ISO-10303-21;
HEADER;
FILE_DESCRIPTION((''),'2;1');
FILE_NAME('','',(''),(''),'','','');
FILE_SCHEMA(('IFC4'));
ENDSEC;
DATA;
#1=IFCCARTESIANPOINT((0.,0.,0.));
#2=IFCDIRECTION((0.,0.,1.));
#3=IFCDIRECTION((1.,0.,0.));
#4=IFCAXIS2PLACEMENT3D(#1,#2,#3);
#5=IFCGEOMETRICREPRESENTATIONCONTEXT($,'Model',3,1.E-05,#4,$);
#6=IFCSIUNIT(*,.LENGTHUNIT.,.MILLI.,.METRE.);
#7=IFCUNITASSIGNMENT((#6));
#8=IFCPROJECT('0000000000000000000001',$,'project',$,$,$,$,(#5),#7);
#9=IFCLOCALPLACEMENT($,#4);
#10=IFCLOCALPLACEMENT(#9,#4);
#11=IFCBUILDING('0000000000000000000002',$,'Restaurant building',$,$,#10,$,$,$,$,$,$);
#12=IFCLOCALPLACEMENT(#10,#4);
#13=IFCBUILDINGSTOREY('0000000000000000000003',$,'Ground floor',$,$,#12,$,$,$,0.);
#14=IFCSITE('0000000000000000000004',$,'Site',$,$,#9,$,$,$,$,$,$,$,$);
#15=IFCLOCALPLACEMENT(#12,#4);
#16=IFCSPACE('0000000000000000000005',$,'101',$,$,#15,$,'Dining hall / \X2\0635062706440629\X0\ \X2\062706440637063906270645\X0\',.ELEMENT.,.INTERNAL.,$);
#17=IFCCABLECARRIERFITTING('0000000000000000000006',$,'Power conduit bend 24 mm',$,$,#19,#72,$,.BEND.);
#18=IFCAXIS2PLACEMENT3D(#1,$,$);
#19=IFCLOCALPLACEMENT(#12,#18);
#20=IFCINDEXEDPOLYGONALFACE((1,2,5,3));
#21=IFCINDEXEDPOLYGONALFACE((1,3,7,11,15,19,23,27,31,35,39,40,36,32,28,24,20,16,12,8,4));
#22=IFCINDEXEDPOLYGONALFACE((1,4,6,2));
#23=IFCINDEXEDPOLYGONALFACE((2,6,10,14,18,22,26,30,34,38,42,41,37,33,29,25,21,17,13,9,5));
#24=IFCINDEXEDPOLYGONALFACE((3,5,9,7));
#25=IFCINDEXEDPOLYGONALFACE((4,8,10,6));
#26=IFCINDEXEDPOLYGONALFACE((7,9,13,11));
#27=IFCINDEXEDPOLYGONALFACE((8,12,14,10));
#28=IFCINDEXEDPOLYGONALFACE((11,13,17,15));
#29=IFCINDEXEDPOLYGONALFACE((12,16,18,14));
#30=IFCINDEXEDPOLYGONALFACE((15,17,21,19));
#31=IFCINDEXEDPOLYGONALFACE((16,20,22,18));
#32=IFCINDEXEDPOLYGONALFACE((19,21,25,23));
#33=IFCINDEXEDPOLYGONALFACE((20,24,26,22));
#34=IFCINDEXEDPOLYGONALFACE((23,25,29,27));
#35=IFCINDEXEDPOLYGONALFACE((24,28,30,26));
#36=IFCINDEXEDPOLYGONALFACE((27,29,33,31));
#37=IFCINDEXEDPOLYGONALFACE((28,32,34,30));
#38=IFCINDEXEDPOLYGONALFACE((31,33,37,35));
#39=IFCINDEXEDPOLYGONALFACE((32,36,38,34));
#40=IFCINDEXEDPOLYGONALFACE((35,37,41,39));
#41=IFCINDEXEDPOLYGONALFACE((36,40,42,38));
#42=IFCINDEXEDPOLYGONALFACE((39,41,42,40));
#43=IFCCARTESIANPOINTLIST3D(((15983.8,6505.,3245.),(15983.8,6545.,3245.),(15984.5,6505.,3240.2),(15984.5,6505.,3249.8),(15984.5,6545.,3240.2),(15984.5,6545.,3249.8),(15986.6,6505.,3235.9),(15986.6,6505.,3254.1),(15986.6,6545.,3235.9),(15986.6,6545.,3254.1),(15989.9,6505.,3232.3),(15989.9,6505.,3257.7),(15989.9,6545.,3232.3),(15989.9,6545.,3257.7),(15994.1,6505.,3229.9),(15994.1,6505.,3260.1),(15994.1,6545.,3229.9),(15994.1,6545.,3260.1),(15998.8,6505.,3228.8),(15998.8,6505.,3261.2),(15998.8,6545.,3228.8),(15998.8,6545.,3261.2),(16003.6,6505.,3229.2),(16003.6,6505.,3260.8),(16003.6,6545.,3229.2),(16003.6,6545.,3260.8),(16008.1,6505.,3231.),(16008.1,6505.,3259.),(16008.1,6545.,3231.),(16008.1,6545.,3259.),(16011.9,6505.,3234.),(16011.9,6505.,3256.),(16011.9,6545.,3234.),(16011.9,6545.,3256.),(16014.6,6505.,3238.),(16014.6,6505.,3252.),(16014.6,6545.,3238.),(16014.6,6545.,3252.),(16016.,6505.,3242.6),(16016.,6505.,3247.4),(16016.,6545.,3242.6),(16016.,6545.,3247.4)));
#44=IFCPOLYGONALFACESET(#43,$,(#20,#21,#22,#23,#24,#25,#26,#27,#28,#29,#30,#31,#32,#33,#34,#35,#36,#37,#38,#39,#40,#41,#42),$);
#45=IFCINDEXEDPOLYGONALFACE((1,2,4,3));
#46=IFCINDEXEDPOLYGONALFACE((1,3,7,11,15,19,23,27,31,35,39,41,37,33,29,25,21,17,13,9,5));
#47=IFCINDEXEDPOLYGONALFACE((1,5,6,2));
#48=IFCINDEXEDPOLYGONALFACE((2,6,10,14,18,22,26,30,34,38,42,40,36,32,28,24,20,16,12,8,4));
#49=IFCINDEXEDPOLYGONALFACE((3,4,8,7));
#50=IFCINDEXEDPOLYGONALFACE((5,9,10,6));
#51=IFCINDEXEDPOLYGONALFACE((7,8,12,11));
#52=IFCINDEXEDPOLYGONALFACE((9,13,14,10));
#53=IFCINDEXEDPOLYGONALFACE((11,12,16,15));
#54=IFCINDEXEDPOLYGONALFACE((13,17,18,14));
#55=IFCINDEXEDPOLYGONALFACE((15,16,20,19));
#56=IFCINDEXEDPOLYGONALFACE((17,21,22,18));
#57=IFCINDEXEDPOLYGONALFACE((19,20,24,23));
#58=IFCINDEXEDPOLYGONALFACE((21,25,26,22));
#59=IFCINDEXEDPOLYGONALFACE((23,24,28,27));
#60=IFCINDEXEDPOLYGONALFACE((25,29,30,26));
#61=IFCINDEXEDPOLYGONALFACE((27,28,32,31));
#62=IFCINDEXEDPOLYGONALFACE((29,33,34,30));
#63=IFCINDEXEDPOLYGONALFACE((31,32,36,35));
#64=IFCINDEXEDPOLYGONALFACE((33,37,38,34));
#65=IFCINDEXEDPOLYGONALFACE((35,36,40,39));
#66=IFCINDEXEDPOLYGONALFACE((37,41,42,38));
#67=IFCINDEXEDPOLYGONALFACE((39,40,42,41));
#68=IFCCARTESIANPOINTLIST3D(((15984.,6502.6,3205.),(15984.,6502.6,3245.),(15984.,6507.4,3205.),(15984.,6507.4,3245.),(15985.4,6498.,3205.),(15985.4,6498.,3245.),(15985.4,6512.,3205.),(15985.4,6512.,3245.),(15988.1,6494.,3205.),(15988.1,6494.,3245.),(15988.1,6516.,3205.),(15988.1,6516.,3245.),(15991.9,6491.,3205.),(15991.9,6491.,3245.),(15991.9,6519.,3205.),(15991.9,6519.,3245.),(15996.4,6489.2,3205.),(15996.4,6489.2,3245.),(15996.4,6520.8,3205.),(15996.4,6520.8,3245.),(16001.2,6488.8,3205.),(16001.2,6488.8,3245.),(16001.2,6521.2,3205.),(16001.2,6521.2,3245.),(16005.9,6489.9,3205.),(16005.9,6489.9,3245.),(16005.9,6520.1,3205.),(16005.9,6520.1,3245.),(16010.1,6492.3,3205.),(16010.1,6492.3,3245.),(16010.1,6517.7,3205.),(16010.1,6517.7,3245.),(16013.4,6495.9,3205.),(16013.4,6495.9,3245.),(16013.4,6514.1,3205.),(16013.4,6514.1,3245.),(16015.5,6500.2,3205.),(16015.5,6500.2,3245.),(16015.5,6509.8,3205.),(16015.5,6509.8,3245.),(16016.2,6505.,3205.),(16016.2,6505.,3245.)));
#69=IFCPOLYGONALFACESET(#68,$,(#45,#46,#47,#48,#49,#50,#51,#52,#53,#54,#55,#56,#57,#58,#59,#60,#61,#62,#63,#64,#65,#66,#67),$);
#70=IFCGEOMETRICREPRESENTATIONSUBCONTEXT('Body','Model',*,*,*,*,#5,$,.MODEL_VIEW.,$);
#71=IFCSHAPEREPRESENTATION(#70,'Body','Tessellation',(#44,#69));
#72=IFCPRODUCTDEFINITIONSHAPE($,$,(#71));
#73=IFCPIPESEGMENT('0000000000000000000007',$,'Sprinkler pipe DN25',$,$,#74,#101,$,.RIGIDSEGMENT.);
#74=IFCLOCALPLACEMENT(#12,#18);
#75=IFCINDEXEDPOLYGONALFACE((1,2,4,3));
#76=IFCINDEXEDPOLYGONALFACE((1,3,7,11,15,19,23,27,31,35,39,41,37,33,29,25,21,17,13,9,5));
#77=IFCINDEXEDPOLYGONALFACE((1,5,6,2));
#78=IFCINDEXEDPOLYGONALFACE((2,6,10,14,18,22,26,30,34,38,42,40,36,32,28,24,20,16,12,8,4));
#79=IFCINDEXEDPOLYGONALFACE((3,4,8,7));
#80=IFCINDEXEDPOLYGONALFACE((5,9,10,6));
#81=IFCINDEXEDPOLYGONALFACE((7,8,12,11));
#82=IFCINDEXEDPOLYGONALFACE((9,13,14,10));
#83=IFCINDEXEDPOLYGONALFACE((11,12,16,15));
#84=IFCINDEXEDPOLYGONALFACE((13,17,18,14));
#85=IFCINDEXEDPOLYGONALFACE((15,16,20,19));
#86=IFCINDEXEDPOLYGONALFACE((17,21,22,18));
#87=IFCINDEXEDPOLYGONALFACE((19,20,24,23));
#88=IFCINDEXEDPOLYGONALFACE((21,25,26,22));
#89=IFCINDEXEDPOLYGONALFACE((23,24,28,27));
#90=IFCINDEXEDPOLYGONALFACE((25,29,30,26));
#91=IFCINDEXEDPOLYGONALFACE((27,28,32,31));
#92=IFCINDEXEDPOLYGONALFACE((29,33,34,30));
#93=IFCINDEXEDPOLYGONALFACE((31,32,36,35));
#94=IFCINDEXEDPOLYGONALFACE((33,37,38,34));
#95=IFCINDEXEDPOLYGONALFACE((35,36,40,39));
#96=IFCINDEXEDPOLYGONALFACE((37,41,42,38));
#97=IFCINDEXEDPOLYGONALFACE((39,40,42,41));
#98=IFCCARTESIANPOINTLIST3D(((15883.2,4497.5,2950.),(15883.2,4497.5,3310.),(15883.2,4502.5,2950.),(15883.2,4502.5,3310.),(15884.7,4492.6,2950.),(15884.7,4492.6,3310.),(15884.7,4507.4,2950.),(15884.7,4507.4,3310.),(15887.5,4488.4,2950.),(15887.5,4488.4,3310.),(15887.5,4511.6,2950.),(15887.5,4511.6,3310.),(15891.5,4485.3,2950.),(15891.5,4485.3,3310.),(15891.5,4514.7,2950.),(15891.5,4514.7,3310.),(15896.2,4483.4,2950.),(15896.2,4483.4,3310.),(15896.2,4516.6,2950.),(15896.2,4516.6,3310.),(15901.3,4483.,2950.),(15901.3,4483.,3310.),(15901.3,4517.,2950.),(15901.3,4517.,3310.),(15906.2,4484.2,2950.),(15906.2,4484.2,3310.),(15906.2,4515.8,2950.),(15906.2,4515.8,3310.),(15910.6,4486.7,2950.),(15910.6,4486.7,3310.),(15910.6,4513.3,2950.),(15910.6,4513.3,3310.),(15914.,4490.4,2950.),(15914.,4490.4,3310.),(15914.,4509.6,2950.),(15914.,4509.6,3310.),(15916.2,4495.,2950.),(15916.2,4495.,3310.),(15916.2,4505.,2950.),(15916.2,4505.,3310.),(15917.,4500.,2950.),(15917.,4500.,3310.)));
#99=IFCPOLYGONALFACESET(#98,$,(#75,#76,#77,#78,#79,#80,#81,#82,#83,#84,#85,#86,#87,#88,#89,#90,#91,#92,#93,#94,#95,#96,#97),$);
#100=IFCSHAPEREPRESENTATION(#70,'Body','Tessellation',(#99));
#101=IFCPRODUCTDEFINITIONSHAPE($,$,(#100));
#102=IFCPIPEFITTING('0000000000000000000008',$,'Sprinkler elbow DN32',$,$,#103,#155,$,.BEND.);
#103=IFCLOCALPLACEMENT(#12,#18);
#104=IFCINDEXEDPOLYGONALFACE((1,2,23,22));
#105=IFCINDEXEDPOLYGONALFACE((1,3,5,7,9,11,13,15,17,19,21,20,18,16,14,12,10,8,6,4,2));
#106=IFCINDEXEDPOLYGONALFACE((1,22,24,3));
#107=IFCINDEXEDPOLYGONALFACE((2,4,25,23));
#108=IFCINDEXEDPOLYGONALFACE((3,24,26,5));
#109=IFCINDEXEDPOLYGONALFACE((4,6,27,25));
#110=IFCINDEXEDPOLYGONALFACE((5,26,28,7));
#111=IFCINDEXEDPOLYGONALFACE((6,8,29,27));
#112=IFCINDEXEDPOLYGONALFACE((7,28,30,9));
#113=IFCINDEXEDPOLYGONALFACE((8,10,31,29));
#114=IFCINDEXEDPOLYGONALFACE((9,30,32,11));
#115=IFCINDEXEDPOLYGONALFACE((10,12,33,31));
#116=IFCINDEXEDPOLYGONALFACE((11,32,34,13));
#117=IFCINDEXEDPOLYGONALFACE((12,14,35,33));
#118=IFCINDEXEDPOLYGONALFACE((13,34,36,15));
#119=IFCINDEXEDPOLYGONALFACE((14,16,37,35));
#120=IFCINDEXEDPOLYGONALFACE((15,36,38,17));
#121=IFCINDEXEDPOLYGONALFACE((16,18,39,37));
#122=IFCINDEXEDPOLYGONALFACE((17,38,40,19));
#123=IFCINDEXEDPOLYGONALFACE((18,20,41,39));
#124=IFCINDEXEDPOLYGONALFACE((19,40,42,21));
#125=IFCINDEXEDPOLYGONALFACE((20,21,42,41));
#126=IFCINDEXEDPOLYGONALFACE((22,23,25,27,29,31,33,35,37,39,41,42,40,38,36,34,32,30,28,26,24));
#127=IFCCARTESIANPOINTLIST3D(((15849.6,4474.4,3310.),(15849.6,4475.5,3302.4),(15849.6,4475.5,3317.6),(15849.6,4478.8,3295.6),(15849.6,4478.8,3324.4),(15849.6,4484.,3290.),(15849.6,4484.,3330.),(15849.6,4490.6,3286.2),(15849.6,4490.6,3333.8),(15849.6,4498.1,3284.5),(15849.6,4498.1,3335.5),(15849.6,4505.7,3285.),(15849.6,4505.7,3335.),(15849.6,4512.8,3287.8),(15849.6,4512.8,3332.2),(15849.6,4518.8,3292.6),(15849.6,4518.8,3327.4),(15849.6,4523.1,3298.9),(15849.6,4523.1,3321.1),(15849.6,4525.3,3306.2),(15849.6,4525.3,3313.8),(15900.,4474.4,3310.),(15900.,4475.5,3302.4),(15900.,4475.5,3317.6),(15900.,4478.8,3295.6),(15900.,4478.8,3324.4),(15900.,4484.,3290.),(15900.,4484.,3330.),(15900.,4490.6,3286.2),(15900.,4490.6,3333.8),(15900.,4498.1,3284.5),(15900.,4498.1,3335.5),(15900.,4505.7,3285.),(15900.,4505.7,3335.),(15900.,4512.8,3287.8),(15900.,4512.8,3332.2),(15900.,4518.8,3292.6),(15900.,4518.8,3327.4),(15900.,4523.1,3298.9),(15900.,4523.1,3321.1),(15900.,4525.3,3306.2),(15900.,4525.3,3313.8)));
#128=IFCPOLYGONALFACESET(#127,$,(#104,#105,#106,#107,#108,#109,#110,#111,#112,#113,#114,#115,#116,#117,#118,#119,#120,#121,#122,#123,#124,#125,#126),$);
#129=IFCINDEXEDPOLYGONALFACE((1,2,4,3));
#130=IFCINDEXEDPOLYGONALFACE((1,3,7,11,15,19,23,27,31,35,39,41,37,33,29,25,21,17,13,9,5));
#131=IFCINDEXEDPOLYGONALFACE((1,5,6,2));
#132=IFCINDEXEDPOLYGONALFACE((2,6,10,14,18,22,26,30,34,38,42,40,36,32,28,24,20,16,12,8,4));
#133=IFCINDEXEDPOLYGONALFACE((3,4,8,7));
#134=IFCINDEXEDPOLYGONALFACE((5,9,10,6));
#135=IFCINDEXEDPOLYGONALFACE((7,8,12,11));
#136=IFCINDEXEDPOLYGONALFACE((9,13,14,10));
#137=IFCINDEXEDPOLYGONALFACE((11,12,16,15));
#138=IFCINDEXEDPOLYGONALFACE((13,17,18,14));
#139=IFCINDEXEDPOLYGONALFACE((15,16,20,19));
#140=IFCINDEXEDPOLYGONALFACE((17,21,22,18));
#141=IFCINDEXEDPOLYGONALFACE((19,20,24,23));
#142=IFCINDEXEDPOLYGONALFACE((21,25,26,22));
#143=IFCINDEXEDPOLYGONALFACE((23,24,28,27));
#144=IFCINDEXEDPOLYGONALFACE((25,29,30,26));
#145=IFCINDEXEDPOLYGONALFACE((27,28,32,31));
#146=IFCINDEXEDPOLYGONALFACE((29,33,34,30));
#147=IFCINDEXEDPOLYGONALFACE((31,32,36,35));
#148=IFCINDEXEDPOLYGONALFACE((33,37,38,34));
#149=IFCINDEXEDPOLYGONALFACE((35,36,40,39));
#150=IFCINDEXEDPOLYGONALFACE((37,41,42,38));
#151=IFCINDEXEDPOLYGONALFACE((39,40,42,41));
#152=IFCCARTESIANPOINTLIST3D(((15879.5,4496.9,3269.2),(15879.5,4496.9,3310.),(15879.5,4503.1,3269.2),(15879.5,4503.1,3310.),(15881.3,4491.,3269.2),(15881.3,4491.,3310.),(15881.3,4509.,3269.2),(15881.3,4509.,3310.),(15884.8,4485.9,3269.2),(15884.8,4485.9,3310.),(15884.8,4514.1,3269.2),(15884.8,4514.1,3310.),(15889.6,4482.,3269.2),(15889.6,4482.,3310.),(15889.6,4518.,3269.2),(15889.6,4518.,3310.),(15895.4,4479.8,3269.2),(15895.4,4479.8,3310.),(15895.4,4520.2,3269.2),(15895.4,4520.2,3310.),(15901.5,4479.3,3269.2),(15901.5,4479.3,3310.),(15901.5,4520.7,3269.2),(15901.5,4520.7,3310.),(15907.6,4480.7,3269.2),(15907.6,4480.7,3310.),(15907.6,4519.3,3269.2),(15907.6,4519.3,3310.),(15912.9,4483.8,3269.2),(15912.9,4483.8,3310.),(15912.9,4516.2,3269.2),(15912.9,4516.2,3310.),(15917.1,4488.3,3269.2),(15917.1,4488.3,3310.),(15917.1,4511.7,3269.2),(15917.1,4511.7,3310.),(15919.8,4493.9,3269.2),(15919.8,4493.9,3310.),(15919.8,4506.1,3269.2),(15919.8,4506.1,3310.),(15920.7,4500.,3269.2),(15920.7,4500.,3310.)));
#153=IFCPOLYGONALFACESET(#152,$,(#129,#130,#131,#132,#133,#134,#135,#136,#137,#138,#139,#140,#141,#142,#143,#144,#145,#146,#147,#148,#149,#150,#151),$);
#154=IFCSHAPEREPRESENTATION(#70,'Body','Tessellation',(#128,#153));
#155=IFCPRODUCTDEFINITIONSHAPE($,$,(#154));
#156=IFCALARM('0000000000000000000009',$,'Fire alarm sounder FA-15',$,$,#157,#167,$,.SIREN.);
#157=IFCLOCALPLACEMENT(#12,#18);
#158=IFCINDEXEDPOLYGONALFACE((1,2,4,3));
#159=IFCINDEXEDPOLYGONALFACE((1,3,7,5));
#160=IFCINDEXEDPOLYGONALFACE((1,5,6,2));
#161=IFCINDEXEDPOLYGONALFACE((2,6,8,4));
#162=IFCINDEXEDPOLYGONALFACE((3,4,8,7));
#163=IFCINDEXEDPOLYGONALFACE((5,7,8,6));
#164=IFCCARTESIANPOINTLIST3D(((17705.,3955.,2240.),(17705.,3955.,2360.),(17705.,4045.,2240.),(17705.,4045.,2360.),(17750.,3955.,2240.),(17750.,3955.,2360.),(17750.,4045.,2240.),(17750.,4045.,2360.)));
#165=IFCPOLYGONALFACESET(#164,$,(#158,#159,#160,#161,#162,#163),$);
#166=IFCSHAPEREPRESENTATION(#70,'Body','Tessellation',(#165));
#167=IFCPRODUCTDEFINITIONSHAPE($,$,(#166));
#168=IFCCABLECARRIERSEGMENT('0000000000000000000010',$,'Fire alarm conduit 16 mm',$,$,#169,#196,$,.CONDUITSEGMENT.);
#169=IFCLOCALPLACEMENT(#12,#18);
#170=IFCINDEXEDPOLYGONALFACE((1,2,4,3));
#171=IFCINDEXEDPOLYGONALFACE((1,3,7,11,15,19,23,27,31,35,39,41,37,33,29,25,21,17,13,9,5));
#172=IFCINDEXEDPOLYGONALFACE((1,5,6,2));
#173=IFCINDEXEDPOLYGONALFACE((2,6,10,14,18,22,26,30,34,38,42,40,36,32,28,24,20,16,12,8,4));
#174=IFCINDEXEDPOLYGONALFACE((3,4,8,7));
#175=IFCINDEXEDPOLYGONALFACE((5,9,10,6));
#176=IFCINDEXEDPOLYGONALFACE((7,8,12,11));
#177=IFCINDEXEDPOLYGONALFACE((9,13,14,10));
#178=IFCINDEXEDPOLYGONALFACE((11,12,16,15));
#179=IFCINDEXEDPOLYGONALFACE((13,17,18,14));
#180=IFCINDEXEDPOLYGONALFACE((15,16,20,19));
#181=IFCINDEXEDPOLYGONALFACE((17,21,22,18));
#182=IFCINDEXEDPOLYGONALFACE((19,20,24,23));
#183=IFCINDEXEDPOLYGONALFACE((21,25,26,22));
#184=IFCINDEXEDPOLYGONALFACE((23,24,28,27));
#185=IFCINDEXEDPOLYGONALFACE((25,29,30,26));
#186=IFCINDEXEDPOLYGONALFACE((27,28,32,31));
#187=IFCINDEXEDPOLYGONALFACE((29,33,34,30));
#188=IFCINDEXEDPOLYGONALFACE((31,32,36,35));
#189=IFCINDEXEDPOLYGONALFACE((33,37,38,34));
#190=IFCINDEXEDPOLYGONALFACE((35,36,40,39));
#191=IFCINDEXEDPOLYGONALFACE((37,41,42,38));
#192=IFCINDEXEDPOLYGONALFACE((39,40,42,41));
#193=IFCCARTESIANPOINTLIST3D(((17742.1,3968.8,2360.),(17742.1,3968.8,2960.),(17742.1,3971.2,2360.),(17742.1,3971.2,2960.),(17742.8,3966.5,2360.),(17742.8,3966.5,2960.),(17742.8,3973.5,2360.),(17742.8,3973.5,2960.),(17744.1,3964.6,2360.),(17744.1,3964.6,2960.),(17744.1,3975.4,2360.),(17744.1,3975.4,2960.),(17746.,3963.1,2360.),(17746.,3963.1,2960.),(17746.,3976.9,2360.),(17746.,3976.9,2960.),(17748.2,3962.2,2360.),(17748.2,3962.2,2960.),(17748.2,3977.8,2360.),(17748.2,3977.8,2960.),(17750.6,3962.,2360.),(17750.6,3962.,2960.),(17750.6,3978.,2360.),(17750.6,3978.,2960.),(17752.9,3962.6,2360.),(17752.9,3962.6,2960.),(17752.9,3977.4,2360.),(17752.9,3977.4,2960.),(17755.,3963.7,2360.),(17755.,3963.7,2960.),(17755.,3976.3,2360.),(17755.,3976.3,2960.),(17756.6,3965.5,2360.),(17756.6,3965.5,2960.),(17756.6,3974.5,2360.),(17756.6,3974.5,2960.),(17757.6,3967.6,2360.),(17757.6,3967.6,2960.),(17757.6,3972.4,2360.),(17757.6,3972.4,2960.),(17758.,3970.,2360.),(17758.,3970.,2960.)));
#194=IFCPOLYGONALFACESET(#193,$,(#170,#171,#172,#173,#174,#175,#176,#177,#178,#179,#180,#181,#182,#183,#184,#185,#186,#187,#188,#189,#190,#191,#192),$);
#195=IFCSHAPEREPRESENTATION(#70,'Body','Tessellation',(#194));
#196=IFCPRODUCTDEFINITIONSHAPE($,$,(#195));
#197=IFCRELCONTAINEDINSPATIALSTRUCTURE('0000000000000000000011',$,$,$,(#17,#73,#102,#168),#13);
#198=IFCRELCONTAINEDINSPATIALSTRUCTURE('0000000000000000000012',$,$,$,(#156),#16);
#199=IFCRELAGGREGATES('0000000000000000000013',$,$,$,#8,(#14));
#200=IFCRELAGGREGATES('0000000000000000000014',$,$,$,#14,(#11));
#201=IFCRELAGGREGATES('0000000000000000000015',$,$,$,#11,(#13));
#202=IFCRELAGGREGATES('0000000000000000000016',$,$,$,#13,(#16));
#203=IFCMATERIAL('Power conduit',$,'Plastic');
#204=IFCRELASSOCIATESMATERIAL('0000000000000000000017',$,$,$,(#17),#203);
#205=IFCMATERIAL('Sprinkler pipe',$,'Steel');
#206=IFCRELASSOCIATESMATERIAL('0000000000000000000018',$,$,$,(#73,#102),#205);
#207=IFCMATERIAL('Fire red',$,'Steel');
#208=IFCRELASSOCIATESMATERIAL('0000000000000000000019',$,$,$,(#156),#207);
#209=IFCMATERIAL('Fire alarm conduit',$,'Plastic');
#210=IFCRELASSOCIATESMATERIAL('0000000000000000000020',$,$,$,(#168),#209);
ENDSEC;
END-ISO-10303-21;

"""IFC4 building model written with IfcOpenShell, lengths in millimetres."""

from ifc_helpers import new_model, si_unit, frame, origin_with_axes, origin_2d, place, context, subcontext, project, spatial, rectangle, circle, extrude, material, element, save


model = new_model("IFC4")

# Units and contexts
model_context = context("Model", 3, precision=1e-05, world=origin_with_axes())
body_context = subcontext(model_context, "Body", "Model", "MODEL_VIEW")
ifc_project = project(units=[si_unit("LENGTHUNIT", "METRE", prefix="MILLI")], contexts=[model_context])

# Site, building, storey
site_placement = place(None, origin_with_axes())
site = spatial("IfcSite", under=ifc_project, at=site_placement, Name="Site")
building_placement = place(site_placement, origin_with_axes())
building = spatial("IfcBuilding", under=site, at=building_placement, Name="Restaurant building")
storey_placement = place(building_placement, origin_with_axes())
storey = spatial("IfcBuildingStorey", under=building, at=storey_placement, Name="Ground floor", Elevation=0.0)

# Shared definitions
space_1_placement = place(storey_placement, origin_with_axes())
space_1 = spatial("IfcSpace", under=storey, at=space_1_placement, Name="101", LongName="Dining hall / صالة الطعام", CompositionType="ELEMENT", PredefinedType="INTERNAL")

# Shared definitions
ifc_material_1 = material(Name="Power conduit", Category="Plastic")

# Cable carrier fitting
for number, where, name in (
    (1, (16000.0, 6505.0, 3245.0), "Power conduit bend 24 mm"),
):
    element("IfcCableCarrierFitting", number, at=place(storey_placement, frame(where)), inside=storey, material=ifc_material_1, Name=name, PredefinedType="BEND", context=body_context, shape_type="SweptSolid", body=[
        extrude(circle(Radius=16.2, at=origin_2d()), frame((0.0, 0.0, 0.0), z_axis=(0.0, 1.0, 0.0), x_axis=(-1.0, 0.0, 0.0)), (0.0, 0.0, 1.0), 40.0),
        extrude(circle(Radius=16.2, at=origin_2d()), frame((0.0, 0.0, 0.0), z_axis=(0.0, 0.0, -1.0), x_axis=(1.0, 0.0, 0.0)), (0.0, 0.0, 1.0), 40.0),
    ])

# Pipe segment
ifc_material_2 = material(Name="Sprinkler pipe", Category="Steel")
pipe_segment_placement = place(storey_placement, frame((15900.0, 4500.0, 3310.0)))
element("IfcPipeSegment", 2, at=pipe_segment_placement, inside=storey, material=ifc_material_2, Name="Sprinkler pipe DN25", PredefinedType="RIGIDSEGMENT", context=body_context, shape_type="SweptSolid", body=[
    extrude(circle(Radius=17.0, at=origin_2d()), frame((0.0, 0.0, 0.0), z_axis=(0.0, 0.0, -1.0), x_axis=(1.0, 0.0, 0.0)), (0.0, 0.0, 1.0), 360.0),
])

# Pipe fitting
pipe_fitting_placement = place(storey_placement, frame((15900.0, 4500.0, 3310.0)))
element("IfcPipeFitting", 3, at=pipe_fitting_placement, inside=storey, material=ifc_material_2, Name="Sprinkler elbow DN32", PredefinedType="BEND", context=body_context, shape_type="SweptSolid", body=[
    extrude(circle(Radius=25.6, at=origin_2d()), frame((0.0, 0.0, 0.0), z_axis=(-1.0, 0.0, 0.0), x_axis=(0.0, -1.0, 0.0)), (0.0, 0.0, 1.0), 50.4),
    extrude(circle(Radius=20.7, at=origin_2d()), frame((0.0, 0.0, 0.0), z_axis=(0.0, 0.0, -1.0), x_axis=(1.0, 0.0, 0.0)), (0.0, 0.0, 1.0), 40.8),
])

# Alarm
ifc_material_3 = material(Name="Fire red", Category="Steel")
alarm_placement = place(storey_placement, frame((17750.0, 4000.0, 2300.0)))
element("IfcAlarm", 4, at=alarm_placement, inside=space_1, material=ifc_material_3, Name="Fire alarm sounder FA-15", PredefinedType="SIREN", context=body_context, shape_type="SweptSolid", body=[
    extrude(rectangle(XDim=45.0, YDim=90.0, at=origin_2d()), frame((-22.5, 0.0, -60.0)), (0.0, 0.0, 1.0), 120.0),
])

# Cable carrier segment
ifc_material_4 = material(Name="Fire alarm conduit", Category="Plastic")
cable_carrier_segment_1_placement = place(storey_placement, frame((17750.0, 3970.0, 2960.0)))
element("IfcCableCarrierSegment", 5, at=cable_carrier_segment_1_placement, inside=storey, material=ifc_material_4, Name="Fire alarm conduit 16 mm", PredefinedType="CONDUITSEGMENT", context=body_context, shape_type="SweptSolid", body=[
    extrude(circle(Radius=8.0, at=origin_2d()), frame((0.0, 0.0, 0.0), z_axis=(0.0, 0.0, -1.0), x_axis=(1.0, 0.0, 0.0)), (0.0, 0.0, 1.0), 600.0),
])

save(model, "model.ifc")
